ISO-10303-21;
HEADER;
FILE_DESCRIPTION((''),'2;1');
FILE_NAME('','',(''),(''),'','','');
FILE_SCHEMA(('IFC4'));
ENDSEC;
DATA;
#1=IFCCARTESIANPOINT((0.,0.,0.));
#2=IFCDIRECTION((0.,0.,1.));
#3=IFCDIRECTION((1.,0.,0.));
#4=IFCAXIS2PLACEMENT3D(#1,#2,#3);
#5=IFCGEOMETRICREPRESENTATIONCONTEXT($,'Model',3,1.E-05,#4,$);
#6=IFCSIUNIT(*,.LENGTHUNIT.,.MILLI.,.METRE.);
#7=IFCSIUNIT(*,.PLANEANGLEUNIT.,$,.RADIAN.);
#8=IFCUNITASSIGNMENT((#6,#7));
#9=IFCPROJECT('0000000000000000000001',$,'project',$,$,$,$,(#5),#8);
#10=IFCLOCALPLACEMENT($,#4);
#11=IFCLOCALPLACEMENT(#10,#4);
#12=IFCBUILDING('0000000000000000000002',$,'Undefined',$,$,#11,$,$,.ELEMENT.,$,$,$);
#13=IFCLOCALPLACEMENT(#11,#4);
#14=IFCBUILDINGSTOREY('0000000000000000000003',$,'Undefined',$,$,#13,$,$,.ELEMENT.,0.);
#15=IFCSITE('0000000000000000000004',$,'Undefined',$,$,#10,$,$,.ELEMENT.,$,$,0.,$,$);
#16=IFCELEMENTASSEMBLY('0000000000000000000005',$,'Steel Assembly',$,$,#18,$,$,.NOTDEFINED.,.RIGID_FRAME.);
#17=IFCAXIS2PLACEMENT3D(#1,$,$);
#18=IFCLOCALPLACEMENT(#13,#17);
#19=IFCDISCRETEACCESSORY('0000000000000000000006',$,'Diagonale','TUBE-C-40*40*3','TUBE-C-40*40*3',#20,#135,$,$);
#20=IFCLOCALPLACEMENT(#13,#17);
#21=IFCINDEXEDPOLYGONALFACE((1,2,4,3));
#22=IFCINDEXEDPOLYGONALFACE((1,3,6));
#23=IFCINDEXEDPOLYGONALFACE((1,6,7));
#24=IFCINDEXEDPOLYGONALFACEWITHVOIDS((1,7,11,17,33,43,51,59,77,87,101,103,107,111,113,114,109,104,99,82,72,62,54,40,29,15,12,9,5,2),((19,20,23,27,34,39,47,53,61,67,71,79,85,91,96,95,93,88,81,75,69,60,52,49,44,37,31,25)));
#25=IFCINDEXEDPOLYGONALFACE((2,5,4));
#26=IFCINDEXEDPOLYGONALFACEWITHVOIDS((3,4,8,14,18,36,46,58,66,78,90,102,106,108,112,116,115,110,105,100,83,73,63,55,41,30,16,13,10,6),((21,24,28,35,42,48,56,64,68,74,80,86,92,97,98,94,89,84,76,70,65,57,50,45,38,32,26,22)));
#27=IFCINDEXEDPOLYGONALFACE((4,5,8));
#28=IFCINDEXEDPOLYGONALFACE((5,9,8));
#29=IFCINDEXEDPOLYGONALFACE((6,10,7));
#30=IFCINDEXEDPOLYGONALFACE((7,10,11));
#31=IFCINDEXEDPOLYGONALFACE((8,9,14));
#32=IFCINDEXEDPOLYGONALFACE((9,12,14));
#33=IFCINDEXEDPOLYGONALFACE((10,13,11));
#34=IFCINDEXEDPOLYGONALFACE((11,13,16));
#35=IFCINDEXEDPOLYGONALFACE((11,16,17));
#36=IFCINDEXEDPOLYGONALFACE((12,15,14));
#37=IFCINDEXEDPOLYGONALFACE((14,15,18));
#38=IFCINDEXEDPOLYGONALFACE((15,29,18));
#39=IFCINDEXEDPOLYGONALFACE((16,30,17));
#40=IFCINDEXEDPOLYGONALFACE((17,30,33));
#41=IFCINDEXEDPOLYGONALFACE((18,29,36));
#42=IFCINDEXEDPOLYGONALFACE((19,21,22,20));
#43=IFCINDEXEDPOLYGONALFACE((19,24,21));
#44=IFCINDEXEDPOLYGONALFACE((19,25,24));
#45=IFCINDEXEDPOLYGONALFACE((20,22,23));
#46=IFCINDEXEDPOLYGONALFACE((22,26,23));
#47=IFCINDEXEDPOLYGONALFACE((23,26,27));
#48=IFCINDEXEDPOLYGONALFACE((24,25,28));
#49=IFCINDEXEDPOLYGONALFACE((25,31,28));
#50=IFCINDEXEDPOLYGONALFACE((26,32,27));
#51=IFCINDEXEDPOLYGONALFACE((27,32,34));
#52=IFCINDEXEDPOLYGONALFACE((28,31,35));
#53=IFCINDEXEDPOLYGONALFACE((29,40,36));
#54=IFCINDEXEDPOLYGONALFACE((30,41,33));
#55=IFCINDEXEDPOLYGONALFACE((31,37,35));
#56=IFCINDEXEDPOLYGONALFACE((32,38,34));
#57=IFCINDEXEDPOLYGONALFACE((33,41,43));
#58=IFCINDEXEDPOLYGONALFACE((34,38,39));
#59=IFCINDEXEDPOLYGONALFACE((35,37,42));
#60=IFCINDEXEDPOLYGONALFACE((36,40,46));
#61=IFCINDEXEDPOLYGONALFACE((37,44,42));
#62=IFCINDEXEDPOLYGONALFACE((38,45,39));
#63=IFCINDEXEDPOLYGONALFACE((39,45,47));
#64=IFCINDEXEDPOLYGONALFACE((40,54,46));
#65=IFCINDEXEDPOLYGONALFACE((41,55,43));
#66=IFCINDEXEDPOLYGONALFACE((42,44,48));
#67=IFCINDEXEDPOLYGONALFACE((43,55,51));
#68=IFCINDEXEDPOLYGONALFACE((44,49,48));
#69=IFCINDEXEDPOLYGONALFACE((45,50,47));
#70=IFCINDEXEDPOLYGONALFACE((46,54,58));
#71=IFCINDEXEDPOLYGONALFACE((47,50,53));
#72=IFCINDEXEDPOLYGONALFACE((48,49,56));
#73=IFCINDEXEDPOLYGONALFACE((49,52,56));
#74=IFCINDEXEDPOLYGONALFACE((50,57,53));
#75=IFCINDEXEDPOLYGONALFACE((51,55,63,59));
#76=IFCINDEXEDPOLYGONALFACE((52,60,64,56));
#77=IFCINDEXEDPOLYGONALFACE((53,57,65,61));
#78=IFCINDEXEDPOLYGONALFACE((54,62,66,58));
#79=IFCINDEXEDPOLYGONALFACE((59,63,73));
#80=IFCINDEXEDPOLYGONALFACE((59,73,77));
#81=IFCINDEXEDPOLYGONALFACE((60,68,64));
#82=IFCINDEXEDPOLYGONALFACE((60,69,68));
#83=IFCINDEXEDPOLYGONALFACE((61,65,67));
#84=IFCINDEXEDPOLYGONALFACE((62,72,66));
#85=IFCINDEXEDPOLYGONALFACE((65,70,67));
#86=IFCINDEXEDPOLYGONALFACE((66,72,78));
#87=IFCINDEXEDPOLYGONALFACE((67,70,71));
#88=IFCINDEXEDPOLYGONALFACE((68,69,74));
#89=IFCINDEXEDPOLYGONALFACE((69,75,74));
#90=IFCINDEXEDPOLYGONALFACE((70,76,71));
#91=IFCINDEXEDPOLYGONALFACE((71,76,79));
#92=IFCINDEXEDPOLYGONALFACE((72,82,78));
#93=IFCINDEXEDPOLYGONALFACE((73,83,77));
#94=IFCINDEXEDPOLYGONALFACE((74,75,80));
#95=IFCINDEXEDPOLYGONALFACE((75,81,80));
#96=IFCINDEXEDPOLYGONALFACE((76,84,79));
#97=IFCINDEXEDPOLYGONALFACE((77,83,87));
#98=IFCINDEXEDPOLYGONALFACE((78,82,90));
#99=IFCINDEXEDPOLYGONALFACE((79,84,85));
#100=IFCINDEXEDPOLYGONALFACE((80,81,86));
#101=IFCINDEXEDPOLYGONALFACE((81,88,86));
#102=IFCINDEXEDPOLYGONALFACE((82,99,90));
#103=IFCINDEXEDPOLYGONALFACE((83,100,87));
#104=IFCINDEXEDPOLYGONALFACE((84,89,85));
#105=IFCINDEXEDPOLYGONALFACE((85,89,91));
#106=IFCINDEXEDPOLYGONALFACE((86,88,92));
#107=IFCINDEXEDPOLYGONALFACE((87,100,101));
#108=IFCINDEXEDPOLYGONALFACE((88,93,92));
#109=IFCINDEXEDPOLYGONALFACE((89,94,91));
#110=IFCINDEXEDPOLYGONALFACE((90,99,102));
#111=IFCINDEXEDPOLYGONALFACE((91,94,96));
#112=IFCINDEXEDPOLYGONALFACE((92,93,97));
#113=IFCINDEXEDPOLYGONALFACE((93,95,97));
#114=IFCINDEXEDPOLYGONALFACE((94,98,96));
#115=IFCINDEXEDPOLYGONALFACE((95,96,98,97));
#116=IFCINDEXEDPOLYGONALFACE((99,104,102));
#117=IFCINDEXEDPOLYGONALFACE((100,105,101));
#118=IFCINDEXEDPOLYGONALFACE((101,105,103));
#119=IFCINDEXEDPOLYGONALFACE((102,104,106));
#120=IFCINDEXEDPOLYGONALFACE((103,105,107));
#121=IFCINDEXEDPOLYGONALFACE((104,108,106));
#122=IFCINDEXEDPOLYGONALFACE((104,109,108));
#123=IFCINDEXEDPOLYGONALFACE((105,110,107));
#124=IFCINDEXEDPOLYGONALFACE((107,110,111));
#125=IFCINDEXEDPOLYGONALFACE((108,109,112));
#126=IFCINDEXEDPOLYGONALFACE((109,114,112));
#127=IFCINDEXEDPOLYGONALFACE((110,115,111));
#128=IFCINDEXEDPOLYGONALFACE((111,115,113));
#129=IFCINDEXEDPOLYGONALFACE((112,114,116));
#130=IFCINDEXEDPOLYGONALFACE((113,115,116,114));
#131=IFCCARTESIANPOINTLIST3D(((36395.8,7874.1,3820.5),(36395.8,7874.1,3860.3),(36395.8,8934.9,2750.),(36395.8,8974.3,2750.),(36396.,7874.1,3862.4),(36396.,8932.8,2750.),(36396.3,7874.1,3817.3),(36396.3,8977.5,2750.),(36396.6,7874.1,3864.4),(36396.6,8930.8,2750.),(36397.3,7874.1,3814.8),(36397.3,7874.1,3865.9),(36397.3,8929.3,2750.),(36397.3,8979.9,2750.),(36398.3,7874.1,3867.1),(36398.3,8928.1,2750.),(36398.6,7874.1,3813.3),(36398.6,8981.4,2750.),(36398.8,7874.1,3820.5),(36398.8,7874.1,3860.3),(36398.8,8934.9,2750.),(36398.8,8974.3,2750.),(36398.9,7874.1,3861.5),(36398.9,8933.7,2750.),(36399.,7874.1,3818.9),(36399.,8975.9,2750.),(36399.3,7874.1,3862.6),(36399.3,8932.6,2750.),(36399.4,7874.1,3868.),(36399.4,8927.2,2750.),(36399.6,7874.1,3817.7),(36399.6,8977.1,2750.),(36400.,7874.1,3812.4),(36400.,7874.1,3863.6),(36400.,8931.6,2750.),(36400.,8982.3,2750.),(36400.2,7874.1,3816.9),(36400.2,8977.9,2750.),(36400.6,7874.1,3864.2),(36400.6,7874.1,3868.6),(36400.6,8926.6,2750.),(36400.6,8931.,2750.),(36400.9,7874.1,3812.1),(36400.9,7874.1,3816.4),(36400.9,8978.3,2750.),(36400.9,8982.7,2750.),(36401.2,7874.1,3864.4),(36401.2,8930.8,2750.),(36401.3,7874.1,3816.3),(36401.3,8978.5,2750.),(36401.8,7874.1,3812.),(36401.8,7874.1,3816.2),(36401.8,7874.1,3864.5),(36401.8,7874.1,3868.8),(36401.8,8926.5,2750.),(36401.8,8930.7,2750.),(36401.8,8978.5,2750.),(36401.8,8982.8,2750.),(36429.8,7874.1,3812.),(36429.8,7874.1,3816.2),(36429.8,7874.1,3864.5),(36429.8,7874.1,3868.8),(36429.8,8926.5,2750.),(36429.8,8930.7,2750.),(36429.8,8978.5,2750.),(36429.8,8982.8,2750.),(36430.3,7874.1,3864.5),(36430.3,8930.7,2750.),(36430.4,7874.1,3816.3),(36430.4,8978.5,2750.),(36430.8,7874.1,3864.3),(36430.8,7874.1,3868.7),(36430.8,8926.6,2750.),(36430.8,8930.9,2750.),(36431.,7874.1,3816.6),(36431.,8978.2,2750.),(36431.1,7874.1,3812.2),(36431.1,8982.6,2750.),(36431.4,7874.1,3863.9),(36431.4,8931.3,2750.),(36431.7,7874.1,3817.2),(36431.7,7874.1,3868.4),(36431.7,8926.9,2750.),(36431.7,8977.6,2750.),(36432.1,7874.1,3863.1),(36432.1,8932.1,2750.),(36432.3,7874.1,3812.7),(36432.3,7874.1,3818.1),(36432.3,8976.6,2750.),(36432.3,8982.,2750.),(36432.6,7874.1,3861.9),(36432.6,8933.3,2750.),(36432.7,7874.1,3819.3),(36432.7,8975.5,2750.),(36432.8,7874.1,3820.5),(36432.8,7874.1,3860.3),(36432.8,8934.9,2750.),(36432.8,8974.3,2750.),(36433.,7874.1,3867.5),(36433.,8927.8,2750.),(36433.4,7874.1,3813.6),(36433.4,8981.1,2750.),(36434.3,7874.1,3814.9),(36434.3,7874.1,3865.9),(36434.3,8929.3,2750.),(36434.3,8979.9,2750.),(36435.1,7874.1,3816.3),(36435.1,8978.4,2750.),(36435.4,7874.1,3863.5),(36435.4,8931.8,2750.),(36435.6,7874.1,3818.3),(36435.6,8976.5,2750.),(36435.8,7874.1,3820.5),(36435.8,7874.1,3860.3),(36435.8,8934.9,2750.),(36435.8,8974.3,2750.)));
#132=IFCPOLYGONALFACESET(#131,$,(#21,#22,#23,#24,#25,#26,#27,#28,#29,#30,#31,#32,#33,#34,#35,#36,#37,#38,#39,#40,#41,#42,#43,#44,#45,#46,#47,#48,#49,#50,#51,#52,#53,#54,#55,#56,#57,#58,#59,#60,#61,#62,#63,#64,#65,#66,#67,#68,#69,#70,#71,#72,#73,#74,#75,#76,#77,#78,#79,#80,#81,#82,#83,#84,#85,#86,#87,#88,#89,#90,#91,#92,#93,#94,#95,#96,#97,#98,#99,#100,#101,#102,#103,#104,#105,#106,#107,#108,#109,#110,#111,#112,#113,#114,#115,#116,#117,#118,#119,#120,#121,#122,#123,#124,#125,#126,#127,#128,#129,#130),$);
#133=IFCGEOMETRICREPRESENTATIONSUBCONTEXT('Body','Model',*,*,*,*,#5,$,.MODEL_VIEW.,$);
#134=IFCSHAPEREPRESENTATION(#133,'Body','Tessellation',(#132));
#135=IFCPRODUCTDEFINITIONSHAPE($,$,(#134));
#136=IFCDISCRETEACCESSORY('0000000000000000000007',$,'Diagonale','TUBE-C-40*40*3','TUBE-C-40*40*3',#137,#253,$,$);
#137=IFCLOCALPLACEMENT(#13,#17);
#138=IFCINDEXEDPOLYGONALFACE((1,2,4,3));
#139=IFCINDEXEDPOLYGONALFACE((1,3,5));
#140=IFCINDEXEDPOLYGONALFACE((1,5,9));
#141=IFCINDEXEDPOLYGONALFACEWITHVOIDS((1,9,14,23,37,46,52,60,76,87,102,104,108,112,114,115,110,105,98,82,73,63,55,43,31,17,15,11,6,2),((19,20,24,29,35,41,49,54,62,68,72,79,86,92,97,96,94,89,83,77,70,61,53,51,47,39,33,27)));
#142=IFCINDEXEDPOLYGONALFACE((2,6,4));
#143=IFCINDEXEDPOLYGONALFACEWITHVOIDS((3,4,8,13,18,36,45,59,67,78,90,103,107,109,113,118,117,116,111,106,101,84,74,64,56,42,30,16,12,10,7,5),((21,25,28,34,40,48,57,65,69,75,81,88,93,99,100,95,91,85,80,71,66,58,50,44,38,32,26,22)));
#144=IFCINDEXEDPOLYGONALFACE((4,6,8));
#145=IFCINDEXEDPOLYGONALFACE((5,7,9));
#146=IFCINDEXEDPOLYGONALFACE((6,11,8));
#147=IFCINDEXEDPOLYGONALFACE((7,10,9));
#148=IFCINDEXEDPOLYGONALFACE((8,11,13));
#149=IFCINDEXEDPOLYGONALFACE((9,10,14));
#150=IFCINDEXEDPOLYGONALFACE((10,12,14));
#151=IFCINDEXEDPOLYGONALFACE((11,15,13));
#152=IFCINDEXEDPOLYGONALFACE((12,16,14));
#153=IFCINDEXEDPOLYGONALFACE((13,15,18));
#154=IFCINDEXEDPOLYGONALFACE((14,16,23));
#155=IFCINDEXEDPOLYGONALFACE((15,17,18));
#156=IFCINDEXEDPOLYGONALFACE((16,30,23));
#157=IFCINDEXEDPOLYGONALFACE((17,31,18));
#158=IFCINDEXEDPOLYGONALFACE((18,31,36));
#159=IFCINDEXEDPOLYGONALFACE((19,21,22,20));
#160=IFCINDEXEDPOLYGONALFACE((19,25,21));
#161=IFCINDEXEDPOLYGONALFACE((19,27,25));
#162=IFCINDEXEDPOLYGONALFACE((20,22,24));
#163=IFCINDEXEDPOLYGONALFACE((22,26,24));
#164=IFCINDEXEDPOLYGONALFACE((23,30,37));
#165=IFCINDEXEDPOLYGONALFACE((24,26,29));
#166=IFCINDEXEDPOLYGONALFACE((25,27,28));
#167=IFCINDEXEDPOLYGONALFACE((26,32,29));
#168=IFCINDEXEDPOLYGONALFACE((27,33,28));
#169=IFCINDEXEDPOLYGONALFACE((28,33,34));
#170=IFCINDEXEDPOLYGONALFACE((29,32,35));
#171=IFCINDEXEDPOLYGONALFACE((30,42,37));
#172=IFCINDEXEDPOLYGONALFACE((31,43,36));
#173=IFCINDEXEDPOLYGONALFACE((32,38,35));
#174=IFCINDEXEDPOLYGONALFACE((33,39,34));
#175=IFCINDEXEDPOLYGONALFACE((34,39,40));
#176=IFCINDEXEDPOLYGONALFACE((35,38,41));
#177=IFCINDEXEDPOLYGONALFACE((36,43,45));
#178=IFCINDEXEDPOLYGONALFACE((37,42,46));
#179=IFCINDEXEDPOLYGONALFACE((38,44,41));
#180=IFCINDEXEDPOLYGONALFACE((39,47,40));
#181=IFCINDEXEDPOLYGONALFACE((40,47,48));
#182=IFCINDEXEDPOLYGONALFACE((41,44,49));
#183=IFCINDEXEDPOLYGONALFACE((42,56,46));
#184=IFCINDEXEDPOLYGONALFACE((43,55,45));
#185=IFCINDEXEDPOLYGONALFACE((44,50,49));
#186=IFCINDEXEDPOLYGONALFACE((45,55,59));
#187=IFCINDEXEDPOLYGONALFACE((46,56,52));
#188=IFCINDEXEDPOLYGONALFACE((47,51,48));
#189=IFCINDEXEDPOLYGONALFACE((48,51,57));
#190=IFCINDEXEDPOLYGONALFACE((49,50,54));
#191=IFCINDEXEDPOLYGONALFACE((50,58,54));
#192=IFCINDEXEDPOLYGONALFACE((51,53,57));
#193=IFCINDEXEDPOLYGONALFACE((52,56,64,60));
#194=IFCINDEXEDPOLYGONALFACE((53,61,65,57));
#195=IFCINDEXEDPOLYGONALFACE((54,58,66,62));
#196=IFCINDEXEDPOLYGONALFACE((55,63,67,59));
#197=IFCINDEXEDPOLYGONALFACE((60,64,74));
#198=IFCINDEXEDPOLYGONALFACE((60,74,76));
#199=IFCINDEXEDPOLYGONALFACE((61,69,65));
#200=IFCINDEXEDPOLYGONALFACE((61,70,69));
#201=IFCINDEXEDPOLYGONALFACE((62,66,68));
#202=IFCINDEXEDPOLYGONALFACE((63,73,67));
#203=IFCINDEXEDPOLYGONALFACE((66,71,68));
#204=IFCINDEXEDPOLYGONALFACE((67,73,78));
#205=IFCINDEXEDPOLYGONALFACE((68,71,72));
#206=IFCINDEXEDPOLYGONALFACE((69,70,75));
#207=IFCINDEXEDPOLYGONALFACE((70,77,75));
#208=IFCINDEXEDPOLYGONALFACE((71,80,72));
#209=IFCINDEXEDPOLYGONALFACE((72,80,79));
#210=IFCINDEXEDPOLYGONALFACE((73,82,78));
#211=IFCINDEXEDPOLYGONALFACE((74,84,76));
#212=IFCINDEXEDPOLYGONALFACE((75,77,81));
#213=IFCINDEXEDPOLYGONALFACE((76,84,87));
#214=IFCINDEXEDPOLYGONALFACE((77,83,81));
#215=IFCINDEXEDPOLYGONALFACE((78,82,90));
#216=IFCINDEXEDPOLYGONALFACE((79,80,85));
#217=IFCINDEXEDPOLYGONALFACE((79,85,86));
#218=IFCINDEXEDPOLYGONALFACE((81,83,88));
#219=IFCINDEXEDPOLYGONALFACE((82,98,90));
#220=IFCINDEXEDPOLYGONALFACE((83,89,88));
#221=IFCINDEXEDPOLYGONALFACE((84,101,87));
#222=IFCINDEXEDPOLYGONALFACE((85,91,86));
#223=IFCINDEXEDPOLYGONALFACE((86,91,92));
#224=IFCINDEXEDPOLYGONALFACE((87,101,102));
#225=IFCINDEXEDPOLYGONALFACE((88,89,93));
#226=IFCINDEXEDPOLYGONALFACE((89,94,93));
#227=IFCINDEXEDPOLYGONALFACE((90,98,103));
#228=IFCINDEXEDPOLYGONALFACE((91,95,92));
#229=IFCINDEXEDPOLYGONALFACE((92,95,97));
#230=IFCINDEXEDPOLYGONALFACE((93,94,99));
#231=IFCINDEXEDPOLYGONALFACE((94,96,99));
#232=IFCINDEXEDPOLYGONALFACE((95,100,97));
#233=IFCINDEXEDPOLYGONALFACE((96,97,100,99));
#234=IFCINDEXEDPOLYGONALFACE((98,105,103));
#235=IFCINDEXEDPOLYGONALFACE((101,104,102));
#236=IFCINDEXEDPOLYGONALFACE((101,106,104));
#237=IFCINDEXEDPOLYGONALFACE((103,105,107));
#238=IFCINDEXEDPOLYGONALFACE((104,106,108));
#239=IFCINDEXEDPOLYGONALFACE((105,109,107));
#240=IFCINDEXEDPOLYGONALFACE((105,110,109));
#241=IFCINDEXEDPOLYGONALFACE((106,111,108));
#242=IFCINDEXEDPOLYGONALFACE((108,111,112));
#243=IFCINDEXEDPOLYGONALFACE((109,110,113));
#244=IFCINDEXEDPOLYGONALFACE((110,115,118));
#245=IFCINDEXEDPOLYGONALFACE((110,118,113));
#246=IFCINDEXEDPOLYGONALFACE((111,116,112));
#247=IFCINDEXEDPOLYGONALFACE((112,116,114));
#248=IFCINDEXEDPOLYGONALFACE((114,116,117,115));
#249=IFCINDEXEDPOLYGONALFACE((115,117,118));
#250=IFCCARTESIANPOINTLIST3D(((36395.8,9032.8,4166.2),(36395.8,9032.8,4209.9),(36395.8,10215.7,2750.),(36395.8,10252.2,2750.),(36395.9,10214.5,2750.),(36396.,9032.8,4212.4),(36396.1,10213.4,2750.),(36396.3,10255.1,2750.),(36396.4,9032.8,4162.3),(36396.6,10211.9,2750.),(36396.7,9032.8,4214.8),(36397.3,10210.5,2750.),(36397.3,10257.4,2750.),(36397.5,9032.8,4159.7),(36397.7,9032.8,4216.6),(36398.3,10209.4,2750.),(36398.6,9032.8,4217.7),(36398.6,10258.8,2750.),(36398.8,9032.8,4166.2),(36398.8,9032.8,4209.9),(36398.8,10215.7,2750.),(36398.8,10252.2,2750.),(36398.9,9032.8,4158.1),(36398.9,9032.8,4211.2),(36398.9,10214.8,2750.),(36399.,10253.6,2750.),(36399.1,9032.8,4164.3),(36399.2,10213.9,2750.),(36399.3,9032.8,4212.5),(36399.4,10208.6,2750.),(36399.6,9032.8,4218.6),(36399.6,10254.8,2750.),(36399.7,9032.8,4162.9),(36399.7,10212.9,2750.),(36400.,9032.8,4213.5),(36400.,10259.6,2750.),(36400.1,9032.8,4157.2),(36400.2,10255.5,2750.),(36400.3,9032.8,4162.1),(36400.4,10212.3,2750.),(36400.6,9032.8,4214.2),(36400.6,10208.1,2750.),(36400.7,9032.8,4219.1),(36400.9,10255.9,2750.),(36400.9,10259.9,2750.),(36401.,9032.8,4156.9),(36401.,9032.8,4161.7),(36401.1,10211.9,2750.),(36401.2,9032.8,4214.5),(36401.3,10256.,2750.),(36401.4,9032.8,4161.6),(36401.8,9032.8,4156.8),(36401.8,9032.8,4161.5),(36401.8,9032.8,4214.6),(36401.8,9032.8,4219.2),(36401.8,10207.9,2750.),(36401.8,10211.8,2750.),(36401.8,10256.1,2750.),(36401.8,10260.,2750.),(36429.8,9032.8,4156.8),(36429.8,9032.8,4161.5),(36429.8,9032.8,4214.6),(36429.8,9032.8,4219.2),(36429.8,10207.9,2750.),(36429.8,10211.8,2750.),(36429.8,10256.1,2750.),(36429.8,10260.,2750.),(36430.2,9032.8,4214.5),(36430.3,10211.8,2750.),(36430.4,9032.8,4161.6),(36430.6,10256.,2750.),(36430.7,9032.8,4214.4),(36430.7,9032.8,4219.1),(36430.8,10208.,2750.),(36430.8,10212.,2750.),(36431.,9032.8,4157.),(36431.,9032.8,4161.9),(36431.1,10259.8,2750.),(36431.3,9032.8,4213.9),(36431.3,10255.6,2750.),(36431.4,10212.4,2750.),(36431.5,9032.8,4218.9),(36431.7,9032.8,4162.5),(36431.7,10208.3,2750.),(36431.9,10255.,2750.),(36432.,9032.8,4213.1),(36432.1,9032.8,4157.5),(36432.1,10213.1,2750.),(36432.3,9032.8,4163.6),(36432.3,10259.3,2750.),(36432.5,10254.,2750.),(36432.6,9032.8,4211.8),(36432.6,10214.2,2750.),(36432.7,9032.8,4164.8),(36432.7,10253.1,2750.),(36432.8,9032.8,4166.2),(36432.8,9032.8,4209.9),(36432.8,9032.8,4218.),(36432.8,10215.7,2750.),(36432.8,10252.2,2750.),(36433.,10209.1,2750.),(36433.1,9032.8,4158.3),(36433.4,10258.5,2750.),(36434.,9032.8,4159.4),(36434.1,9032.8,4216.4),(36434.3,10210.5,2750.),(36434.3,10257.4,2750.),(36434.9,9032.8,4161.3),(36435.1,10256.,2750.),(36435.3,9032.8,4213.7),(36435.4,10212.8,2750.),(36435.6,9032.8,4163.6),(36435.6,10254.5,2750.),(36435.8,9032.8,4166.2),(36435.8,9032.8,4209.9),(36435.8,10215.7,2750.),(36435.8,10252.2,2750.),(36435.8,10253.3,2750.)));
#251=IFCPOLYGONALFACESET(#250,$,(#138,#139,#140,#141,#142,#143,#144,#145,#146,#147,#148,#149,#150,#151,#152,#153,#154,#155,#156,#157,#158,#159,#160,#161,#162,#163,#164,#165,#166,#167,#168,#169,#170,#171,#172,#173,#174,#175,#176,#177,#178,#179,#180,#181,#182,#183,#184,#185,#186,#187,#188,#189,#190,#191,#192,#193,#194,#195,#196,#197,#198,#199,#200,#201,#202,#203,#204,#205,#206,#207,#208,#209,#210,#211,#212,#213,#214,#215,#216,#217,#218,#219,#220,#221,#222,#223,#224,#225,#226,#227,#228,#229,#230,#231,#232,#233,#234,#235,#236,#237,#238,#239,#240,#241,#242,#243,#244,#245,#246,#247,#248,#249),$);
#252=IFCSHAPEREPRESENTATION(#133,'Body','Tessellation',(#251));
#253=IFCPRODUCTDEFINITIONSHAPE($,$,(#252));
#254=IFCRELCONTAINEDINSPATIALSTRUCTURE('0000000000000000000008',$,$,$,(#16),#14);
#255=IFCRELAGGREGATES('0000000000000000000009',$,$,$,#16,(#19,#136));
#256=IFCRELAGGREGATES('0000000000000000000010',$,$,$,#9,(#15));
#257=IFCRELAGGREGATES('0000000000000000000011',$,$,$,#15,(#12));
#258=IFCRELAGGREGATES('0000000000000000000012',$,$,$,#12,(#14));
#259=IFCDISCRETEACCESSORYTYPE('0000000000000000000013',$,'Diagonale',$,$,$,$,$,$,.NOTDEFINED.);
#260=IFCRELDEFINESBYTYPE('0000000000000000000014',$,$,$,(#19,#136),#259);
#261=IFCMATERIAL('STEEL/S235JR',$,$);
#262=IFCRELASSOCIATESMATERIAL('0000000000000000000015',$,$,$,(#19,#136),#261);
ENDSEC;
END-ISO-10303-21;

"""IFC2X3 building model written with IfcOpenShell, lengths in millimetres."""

from ifc_helpers import new_model, si_unit, frame, origin_with_axes, origin_2d_with_axis, place, context, subcontext, project, spatial, hollow_rectangle, extrude, clip, halfspace, material, type_object, element, aggregate, save


model = new_model("IFC2X3")

# Units and contexts
model_context = context("Model", 3, precision=1e-05, world=origin_with_axes())
body_context = subcontext(model_context, "Body", "Model", "MODEL_VIEW")
ifc_project = project(units=[si_unit("LENGTHUNIT", "METRE", prefix="MILLI"), si_unit("PLANEANGLEUNIT", "RADIAN")], contexts=[model_context])

# Site, building, storey
site_placement = place(None, origin_with_axes())
site = spatial("IfcSite", under=ifc_project, at=site_placement, Name="Undefined", CompositionType="ELEMENT", RefElevation=0.0)
building_placement = place(site_placement, origin_with_axes())
building = spatial("IfcBuilding", under=site, at=building_placement, Name="Undefined", CompositionType="ELEMENT")
storey_placement = place(building_placement, origin_with_axes())
storey = spatial("IfcBuildingStorey", under=building, at=storey_placement, Name="Undefined", CompositionType="ELEMENT", Elevation=0.0)

# Shared definitions
ifc_material_1 = material(Name="STEEL/S235JR")

# Element assembly, discrete accessories
assembly_1_placement = place(storey_placement, origin_with_axes())
assembly_1 = element("IfcElementAssembly", 1, at=assembly_1_placement, inside=storey, Name="Steel Assembly", AssemblyPlace="NOTDEFINED", PredefinedType="RIGID_FRAME")
discrete_accessory_type_1 = type_object("IfcDiscreteAccessoryType", Name="Diagonale")
discrete_accessory_1_placement = place(assembly_1_placement, frame((36415.8, 8968.6, 2735.9), z_axis=(0.0, 0.710321, 0.703878), x_axis=(0.0, -0.703878, 0.710321)))
discrete_accessory_1 = element("IfcDiscreteAccessory", 2, at=discrete_accessory_1_placement, type_object=discrete_accessory_type_1, material=ifc_material_1, Name="Diagonale", Description="TUBE-C-40*40*3", ObjectType="TUBE-C-40*40*3", context=body_context, shape_type="Clipping", body=[
    clip(clip(extrude(hollow_rectangle(XDim=40.0, YDim=40.0, WallThickness=3.0, InnerFilletRadius=3.0, OuterFilletRadius=6.0, at=origin_2d_with_axis()), frame((1595.3, 0.0, 0.0), z_axis=(-1.0, 0.0, 0.0), x_axis=(0.0, -1.0, 0.0)), (0.0, 0.0, 1.0), 1615.9), halfspace(frame((1512.1, 0.0, -42.4), z_axis=(0.703878, 0.0, -0.710321), x_axis=(0.710321, 0.0, 0.703878)), False)), halfspace(frame((21.0, 0.0, -1.2), z_axis=(-0.710321, 0.0, -0.703878), x_axis=(0.703878, 0.0, -0.710321)), False)),
])
discrete_accessory_2_placement = place(assembly_1_placement, frame((36415.8, 10244.6, 2737.2), z_axis=(0.0, 0.767483, 0.64107), x_axis=(0.0, -0.64107, 0.767483)))
discrete_accessory_2 = element("IfcDiscreteAccessory", 3, at=discrete_accessory_2_placement, type_object=discrete_accessory_type_1, material=ifc_material_1, Name="Diagonale", Description="TUBE-C-40*40*3", ObjectType="TUBE-C-40*40*3", context=body_context, shape_type="Clipping", body=[
    clip(clip(extrude(hollow_rectangle(XDim=40.0, YDim=40.0, WallThickness=3.0, InnerFilletRadius=3.0, OuterFilletRadius=6.0, at=origin_2d_with_axis()), frame((1931.5, 0.0, 0.0), z_axis=(-1.0, 0.0, 0.0), x_axis=(0.0, -1.0, 0.0)), (0.0, 0.0, 1.0), 1955.8), halfspace(frame((1843.1, 0.0, -39.5), z_axis=(0.64107, 0.0, -0.767483), x_axis=(0.767483, 0.0, 0.64107)), False)), halfspace(frame((17.2, 0.0, -0.6), z_axis=(-0.767483, 0.0, -0.64107), x_axis=(0.64107, 0.0, -0.767483)), False)),
])
aggregate(assembly_1, [discrete_accessory_1, discrete_accessory_2])

save(model, "model.ifc")
